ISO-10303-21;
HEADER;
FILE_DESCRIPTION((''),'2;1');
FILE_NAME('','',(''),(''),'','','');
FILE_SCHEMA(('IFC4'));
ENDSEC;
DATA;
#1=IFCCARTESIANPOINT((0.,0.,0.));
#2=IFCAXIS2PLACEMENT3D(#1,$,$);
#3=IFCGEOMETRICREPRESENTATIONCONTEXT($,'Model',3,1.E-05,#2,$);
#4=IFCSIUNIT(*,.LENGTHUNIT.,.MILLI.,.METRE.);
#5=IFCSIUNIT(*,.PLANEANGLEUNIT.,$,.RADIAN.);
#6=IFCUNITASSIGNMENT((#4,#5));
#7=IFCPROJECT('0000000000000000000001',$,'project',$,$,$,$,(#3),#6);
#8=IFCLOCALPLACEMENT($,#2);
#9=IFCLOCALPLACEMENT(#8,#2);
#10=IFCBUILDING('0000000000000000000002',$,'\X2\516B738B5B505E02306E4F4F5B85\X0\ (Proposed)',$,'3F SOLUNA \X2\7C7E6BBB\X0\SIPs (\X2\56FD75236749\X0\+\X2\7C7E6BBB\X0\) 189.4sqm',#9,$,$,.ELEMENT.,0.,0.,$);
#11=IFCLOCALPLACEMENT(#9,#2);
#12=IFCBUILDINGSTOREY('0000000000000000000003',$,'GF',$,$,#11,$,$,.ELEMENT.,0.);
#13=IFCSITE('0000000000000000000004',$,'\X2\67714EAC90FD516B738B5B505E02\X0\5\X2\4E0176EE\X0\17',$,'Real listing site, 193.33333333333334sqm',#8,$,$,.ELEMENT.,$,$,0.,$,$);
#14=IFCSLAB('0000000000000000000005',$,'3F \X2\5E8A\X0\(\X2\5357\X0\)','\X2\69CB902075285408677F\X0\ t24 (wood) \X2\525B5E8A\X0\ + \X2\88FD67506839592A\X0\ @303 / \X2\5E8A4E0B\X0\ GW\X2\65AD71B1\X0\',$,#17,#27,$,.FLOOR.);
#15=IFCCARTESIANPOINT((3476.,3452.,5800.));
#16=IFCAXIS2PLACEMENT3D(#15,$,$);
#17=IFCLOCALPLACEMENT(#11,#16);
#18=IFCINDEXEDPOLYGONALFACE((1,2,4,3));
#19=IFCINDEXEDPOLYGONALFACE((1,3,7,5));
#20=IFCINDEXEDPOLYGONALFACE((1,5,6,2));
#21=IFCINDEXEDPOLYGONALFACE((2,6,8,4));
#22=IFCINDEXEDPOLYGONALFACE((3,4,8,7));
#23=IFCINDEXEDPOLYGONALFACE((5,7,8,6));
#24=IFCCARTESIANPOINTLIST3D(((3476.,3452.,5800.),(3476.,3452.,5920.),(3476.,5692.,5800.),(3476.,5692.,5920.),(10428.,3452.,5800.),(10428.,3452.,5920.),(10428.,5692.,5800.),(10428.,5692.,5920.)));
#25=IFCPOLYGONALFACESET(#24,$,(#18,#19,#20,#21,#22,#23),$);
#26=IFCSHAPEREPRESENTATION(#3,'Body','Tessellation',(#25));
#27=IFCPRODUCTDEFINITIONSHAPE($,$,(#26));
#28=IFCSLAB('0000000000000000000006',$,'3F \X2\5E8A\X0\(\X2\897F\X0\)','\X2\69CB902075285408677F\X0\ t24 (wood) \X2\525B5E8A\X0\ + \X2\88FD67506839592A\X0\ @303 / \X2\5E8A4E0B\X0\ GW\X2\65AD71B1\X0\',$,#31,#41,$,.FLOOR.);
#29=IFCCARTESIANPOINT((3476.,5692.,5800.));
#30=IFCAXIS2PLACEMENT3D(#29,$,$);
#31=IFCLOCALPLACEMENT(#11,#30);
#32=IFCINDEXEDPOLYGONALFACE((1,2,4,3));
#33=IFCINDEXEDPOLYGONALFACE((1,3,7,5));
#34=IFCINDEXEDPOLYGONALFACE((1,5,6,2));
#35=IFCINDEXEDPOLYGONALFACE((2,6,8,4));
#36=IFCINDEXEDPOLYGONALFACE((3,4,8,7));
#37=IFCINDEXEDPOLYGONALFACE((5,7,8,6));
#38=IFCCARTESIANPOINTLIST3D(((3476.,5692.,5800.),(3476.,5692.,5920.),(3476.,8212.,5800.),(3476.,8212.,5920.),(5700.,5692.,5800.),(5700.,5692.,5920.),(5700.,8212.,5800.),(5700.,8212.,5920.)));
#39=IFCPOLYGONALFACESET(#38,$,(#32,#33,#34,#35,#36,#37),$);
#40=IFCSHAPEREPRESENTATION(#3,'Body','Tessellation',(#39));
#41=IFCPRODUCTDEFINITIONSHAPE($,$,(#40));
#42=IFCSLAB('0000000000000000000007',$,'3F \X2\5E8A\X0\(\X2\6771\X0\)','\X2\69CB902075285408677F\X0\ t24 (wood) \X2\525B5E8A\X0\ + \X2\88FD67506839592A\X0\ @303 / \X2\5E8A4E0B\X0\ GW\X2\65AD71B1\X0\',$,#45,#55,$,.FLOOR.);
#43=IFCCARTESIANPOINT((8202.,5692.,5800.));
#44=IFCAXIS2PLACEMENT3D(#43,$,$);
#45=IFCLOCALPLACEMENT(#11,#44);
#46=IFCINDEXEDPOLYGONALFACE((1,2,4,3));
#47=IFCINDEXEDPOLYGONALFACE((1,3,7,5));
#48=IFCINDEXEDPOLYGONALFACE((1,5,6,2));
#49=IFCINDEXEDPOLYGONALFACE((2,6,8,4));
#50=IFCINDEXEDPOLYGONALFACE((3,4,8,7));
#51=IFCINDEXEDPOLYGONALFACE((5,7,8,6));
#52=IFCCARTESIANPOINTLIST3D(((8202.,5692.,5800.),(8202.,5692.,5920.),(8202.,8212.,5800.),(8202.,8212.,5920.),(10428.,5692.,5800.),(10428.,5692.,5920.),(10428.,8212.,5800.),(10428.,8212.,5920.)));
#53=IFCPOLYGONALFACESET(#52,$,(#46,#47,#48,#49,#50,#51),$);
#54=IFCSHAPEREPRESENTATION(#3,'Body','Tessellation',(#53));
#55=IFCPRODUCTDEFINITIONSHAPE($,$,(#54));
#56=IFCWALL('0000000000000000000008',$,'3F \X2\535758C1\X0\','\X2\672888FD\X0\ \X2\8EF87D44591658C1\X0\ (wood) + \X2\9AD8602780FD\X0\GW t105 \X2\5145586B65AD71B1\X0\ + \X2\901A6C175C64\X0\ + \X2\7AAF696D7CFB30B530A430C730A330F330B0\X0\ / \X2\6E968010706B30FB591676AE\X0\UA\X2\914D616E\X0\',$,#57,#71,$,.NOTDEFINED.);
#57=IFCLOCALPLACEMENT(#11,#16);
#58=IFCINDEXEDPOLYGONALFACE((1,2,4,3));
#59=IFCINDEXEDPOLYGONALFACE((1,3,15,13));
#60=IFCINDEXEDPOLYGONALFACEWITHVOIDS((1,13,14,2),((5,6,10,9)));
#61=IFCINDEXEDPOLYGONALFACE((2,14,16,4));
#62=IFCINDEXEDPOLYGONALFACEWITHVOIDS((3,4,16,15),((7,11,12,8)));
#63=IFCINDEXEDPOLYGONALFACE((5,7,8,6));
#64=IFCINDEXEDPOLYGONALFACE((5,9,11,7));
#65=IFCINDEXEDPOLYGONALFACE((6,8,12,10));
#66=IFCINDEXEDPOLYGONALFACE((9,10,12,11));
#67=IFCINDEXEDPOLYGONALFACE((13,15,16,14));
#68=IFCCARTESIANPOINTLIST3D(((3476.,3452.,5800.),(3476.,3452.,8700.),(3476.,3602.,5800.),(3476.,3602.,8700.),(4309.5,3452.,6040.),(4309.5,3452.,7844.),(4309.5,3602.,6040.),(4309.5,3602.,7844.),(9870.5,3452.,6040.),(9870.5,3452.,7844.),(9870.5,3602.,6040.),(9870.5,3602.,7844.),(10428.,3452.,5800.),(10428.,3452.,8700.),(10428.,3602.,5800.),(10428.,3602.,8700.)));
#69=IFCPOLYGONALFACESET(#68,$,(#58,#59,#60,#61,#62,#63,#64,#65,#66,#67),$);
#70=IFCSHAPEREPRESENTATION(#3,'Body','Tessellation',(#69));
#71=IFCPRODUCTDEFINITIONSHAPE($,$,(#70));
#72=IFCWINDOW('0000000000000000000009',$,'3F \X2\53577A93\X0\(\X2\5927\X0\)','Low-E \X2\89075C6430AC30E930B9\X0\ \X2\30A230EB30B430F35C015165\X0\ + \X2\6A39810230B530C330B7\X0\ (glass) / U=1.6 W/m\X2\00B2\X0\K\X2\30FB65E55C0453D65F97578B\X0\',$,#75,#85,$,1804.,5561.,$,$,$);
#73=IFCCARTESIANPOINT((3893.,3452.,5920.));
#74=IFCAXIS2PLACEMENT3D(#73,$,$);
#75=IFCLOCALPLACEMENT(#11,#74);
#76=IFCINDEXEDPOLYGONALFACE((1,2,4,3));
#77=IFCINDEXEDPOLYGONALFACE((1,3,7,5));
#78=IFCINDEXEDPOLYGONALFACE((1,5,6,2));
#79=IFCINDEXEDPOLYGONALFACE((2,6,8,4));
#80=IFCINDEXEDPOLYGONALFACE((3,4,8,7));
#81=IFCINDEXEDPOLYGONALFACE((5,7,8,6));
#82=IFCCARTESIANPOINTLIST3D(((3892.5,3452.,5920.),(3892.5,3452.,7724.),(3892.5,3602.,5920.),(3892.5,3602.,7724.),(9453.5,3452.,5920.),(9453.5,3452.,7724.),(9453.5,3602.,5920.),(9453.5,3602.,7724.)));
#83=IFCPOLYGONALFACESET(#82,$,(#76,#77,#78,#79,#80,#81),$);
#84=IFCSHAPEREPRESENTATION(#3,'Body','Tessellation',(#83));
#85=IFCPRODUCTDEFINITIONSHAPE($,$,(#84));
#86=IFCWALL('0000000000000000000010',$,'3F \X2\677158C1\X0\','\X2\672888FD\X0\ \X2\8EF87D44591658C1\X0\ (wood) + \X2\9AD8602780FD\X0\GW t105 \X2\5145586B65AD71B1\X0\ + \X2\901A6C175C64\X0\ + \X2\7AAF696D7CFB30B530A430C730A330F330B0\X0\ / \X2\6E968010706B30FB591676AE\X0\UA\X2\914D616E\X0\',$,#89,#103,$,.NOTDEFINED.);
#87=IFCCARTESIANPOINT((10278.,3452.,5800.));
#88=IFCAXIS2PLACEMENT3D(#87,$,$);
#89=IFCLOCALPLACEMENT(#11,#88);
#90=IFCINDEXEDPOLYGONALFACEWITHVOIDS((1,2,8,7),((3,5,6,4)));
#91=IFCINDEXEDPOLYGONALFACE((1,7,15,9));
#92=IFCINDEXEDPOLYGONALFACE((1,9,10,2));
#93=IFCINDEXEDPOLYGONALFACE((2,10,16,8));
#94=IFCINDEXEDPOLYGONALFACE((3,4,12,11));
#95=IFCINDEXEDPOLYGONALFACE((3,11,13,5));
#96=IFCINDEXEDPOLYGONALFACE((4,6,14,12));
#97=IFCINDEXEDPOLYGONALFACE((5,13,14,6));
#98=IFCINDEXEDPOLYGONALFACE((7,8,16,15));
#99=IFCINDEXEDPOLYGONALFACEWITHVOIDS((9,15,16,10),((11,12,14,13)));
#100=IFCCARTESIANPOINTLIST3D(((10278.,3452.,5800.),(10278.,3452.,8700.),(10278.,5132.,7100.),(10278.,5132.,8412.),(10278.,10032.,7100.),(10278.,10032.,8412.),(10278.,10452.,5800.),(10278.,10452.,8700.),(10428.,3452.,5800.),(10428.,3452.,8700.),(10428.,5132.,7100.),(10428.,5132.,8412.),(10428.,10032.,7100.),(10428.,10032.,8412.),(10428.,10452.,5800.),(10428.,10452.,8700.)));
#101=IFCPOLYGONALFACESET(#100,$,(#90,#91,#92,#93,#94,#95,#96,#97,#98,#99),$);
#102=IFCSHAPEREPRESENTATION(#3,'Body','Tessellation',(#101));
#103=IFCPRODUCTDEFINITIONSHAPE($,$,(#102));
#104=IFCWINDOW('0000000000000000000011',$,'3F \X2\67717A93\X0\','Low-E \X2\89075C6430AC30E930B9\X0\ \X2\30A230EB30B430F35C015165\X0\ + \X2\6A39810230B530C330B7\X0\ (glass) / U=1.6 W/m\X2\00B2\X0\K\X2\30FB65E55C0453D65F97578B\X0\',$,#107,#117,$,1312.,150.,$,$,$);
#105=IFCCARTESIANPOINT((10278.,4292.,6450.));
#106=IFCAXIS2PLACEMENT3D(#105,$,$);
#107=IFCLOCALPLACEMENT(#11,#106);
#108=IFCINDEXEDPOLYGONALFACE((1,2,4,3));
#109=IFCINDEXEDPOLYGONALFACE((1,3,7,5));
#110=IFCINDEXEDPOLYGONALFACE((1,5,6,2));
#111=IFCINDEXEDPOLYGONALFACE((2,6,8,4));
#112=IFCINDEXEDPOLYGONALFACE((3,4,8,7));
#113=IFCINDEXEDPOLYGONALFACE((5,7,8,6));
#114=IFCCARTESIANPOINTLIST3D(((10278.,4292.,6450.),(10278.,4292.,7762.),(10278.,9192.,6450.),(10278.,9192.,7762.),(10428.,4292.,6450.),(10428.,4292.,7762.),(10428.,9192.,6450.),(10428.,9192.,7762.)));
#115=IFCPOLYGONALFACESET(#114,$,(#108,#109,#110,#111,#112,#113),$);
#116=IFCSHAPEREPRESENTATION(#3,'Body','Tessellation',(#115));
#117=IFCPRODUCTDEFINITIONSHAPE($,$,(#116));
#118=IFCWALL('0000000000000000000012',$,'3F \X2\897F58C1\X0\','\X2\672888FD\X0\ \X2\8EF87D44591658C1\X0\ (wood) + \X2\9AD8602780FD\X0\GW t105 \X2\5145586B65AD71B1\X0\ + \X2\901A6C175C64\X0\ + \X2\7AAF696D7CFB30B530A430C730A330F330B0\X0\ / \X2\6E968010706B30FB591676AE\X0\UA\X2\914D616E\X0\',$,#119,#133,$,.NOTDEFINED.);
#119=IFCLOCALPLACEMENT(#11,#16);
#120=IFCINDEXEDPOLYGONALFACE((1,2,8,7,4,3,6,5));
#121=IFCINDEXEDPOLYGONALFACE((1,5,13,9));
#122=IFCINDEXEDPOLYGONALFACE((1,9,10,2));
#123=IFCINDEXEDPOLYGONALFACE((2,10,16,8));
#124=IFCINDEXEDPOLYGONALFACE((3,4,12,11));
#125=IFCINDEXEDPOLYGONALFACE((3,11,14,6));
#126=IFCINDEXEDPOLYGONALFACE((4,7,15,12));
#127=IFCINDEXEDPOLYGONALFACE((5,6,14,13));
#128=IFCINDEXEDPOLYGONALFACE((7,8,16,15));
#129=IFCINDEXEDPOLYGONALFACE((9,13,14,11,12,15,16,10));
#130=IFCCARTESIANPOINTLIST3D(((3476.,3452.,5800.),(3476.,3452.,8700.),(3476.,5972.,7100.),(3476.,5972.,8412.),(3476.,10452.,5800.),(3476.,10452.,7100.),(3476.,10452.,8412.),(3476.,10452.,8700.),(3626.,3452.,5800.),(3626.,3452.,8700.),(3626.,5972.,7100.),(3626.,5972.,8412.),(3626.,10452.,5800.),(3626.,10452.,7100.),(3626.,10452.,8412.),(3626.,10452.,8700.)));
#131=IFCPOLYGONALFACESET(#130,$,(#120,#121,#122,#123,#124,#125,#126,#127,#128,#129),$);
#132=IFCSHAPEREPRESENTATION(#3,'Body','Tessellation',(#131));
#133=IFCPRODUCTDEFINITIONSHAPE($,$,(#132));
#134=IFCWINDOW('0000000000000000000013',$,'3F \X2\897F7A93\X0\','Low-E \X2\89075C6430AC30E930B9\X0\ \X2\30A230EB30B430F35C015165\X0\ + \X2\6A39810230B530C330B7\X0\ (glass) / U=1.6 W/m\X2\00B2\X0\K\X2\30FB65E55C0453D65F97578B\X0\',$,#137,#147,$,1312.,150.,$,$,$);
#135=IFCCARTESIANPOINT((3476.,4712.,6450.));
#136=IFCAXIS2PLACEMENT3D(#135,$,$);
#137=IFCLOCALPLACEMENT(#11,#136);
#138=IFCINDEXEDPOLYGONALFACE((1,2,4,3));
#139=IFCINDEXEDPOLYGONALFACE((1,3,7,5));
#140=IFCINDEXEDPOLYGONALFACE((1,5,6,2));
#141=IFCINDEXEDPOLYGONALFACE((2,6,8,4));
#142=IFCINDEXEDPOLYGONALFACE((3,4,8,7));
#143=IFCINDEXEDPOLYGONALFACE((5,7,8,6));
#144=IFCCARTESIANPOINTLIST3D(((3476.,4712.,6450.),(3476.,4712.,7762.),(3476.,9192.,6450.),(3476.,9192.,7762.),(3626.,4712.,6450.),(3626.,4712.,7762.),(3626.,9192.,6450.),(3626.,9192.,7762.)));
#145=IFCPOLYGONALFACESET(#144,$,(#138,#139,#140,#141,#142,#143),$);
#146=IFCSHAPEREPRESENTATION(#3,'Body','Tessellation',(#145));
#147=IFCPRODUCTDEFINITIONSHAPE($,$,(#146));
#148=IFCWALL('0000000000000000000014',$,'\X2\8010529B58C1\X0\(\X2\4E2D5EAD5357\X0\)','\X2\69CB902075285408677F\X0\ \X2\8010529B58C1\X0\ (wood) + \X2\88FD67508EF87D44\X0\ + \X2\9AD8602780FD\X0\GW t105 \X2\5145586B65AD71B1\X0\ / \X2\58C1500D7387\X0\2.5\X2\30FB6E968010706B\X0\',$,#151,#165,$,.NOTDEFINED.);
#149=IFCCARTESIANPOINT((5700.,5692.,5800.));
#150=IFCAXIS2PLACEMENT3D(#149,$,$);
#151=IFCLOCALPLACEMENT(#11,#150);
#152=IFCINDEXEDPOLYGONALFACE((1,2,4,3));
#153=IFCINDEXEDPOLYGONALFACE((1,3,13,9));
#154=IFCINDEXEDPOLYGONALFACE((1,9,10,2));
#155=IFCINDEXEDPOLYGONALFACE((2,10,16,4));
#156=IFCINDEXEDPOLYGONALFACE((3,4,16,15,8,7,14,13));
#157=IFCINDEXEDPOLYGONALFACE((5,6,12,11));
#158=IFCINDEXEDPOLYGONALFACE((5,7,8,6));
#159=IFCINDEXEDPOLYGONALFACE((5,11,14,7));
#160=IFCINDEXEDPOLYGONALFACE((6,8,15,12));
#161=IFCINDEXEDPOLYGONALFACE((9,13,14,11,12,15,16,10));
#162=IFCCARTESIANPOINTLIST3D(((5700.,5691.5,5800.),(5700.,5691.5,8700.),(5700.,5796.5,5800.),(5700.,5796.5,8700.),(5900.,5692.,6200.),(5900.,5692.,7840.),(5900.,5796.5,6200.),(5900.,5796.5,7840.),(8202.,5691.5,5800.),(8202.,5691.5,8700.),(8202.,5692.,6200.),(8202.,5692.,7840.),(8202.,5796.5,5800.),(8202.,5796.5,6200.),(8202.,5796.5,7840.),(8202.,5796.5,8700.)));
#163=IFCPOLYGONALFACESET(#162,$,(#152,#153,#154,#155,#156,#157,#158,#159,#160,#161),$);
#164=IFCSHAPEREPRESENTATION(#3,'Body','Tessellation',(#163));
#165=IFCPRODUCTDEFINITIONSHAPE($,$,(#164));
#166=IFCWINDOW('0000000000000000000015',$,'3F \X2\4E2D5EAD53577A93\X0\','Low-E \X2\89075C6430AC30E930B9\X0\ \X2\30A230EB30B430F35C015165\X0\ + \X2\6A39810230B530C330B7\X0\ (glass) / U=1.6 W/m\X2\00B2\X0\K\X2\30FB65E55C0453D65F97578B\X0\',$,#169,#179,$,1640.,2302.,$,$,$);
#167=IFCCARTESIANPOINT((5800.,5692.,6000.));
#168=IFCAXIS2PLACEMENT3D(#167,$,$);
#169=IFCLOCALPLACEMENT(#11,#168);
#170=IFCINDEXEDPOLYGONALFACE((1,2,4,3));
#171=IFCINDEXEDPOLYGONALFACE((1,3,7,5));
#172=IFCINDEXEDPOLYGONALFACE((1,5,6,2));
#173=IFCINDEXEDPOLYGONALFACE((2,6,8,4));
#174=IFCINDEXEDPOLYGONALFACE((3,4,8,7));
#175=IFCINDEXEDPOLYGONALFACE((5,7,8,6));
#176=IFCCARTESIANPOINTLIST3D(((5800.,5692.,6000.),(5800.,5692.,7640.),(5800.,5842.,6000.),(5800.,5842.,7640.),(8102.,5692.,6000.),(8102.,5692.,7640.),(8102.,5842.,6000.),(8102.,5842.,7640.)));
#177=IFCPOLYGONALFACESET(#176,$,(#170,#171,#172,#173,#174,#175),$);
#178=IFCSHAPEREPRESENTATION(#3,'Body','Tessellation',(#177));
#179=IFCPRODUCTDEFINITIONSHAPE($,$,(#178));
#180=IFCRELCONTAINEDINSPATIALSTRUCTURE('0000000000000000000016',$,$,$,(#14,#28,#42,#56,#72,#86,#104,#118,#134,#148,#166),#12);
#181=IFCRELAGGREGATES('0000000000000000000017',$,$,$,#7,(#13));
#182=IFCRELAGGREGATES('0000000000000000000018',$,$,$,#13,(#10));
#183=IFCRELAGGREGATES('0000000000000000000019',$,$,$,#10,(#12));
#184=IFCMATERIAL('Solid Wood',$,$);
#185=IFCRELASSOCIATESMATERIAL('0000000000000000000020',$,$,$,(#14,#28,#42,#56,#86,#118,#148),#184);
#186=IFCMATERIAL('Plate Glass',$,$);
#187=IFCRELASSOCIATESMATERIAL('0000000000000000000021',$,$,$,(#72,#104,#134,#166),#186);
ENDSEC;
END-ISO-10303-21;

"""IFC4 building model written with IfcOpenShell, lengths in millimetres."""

from ifc_helpers import new_model, si_unit, frame, frame_2d, origin, place, context, project, spatial, rectangle, extrude, material, element, fill, save


model = new_model("IFC4")

# Units and contexts
model_context = context("Model", 3, precision=1e-05, world=origin())
ifc_project = project(units=[si_unit("LENGTHUNIT", "METRE", prefix="MILLI"), si_unit("PLANEANGLEUNIT", "RADIAN")], contexts=[model_context])

# Site, building, storey
site_placement = place(None, origin())
site = spatial("IfcSite", under=ifc_project, at=site_placement, Name="東京都八王子市5丁目17", ObjectType="Real listing site, 193.33333333333334sqm", CompositionType="ELEMENT", RefElevation=0.0)
building_placement = place(site_placement, origin())
building = spatial("IfcBuilding", under=site, at=building_placement, Name="八王子市の住宅 (Proposed)", ObjectType="3F SOLUNA 籾殻SIPs (国産杉+籾殻) 189.4sqm", CompositionType="ELEMENT", ElevationOfRefHeight=0.0, ElevationOfTerrain=0.0)
storey_placement = place(building_placement, origin())
storey = spatial("IfcBuildingStorey", under=building, at=storey_placement, Name="GF", CompositionType="ELEMENT", Elevation=0.0)

# Slabs
ifc_material_1 = material(Name="Solid Wood")
slab_1_placement = place(storey_placement, frame((3476.0, 3452.0, 5800.0)))
element("IfcSlab", 1, at=slab_1_placement, inside=storey, material=ifc_material_1, Name="3F 床(南)", Description="構造用合板 t24 (wood) 剛床 + 製材根太 @303 / 床下 GW断熱", PredefinedType="FLOOR", context=model_context, shape_type="SweptSolid", body=[
    extrude(rectangle(XDim=6952.0, YDim=2240.0, at=frame_2d((3476.0, 1120.0))), frame((3476.0, 3452.0, 5800.0)), (0.0, 0.0, 1.0), 120.0),
])
slab_2_placement = place(storey_placement, frame((3476.0, 5692.0, 5800.0)))
element("IfcSlab", 2, at=slab_2_placement, inside=storey, material=ifc_material_1, Name="3F 床(西)", Description="構造用合板 t24 (wood) 剛床 + 製材根太 @303 / 床下 GW断熱", PredefinedType="FLOOR", context=model_context, shape_type="SweptSolid", body=[
    extrude(rectangle(XDim=2224.0, YDim=2520.0, at=frame_2d((1112.0, 1260.0))), frame((3476.0, 5692.0, 5800.0)), (0.0, 0.0, 1.0), 120.0),
])
slab_3_placement = place(storey_placement, frame((8202.0, 5692.0, 5800.0)))
element("IfcSlab", 3, at=slab_3_placement, inside=storey, material=ifc_material_1, Name="3F 床(東)", Description="構造用合板 t24 (wood) 剛床 + 製材根太 @303 / 床下 GW断熱", PredefinedType="FLOOR", context=model_context, shape_type="SweptSolid", body=[
    extrude(rectangle(XDim=2226.0, YDim=2520.0, at=frame_2d((1113.0, 1260.0))), frame((8202.0, 5692.0, 5800.0)), (0.0, 0.0, 1.0), 120.0),
])

# Walls, openings, windows
wall_1_placement = place(storey_placement, frame((3476.0, 3452.0, 5800.0)))
wall_1 = element("IfcWall", 4, at=wall_1_placement, inside=storey, material=ifc_material_1, Name="3F 南壁", Description="木製 軸組外壁 (wood) + 高性能GW t105 充填断熱 + 通気層 + 窯業系サイディング / 準耐火・外皮UA配慮", PredefinedType="NOTDEFINED", context=model_context, shape_type="SweptSolid", body=[
    extrude(rectangle(XDim=6952.0, YDim=150.0, at=frame_2d((3476.0, 75.0))), frame((3476.0, 3452.0, 5800.0)), (0.0, 0.0, 1.0), 2900.0),
])
opening_1_placement = place(storey_placement, frame((3893.0, 3452.0, 5920.0)))
opening_1 = element("IfcOpeningElement", 5, at=opening_1_placement, cuts=wall_1, PredefinedType="NOTDEFINED", context=model_context, shape_type="SweptSolid", body=[
    extrude(rectangle(XDim=5561.0, YDim=150.0, at=frame_2d((2780.0, 75.0))), frame((3893.0, 3452.0, 5920.0)), (0.0, 0.0, 1.0), 1804.0),
])
ifc_material_2 = material(Name="Plate Glass")
window_1_placement = place(storey_placement, frame((3893.0, 3452.0, 5920.0)))
window_1 = element("IfcWindow", 6, at=window_1_placement, inside=storey, material=ifc_material_2, Name="3F 南窓(大)", Description="Low-E 複層ガラス アルゴン封入 + 樹脂サッシ (glass) / U=1.6 W/m²K・日射取得型", OverallHeight=1804.0, OverallWidth=5561.0, context=model_context, shape_type="SweptSolid", body=[
    extrude(rectangle(XDim=5561.0, YDim=150.0, at=frame_2d((2780.0, 75.0))), frame((3893.0, 3452.0, 5920.0)), (0.0, 0.0, 1.0), 1804.0),
])
fill(opening_1, window_1)
wall_2_placement = place(storey_placement, frame((10278.0, 3452.0, 5800.0)))
wall_2 = element("IfcWall", 7, at=wall_2_placement, inside=storey, material=ifc_material_1, Name="3F 東壁", Description="木製 軸組外壁 (wood) + 高性能GW t105 充填断熱 + 通気層 + 窯業系サイディング / 準耐火・外皮UA配慮", PredefinedType="NOTDEFINED", context=model_context, shape_type="SweptSolid", body=[
    extrude(rectangle(XDim=150.0, YDim=7000.0, at=frame_2d((75.0, 3500.0))), frame((10278.0, 3452.0, 5800.0)), (0.0, 0.0, 1.0), 2900.0),
])
opening_2_placement = place(storey_placement, frame((10278.0, 4292.0, 6450.0)))
opening_2 = element("IfcOpeningElement", 8, at=opening_2_placement, cuts=wall_2, PredefinedType="NOTDEFINED", context=model_context, shape_type="SweptSolid", body=[
    extrude(rectangle(XDim=150.0, YDim=4900.0, at=frame_2d((75.0, 2450.0))), frame((10278.0, 4292.0, 6450.0)), (0.0, 0.0, 1.0), 1312.0),
])
window_2_placement = place(storey_placement, frame((10278.0, 4292.0, 6450.0)))
window_2 = element("IfcWindow", 9, at=window_2_placement, inside=storey, material=ifc_material_2, Name="3F 東窓", Description="Low-E 複層ガラス アルゴン封入 + 樹脂サッシ (glass) / U=1.6 W/m²K・日射取得型", OverallHeight=1312.0, OverallWidth=150.0, context=model_context, shape_type="SweptSolid", body=[
    extrude(rectangle(XDim=150.0, YDim=4900.0, at=frame_2d((75.0, 2450.0))), frame((10278.0, 4292.0, 6450.0)), (0.0, 0.0, 1.0), 1312.0),
])
fill(opening_2, window_2)
wall_3_placement = place(storey_placement, frame((3476.0, 3452.0, 5800.0)))
wall_3 = element("IfcWall", 10, at=wall_3_placement, inside=storey, material=ifc_material_1, Name="3F 西壁", Description="木製 軸組外壁 (wood) + 高性能GW t105 充填断熱 + 通気層 + 窯業系サイディング / 準耐火・外皮UA配慮", PredefinedType="NOTDEFINED", context=model_context, shape_type="SweptSolid", body=[
    extrude(rectangle(XDim=150.0, YDim=7000.0, at=frame_2d((75.0, 3500.0))), frame((3476.0, 3452.0, 5800.0)), (0.0, 0.0, 1.0), 2900.0),
])
opening_3_placement = place(storey_placement, frame((3476.0, 4712.0, 6450.0)))
opening_3 = element("IfcOpeningElement", 11, at=opening_3_placement, cuts=wall_3, PredefinedType="NOTDEFINED", context=model_context, shape_type="SweptSolid", body=[
    extrude(rectangle(XDim=150.0, YDim=4480.0, at=frame_2d((75.0, 2240.0))), frame((3476.0, 4712.0, 6450.0)), (0.0, 0.0, 1.0), 1312.0),
])
window_3_placement = place(storey_placement, frame((3476.0, 4712.0, 6450.0)))
window_3 = element("IfcWindow", 12, at=window_3_placement, inside=storey, material=ifc_material_2, Name="3F 西窓", Description="Low-E 複層ガラス アルゴン封入 + 樹脂サッシ (glass) / U=1.6 W/m²K・日射取得型", OverallHeight=1312.0, OverallWidth=150.0, context=model_context, shape_type="SweptSolid", body=[
    extrude(rectangle(XDim=150.0, YDim=4480.0, at=frame_2d((75.0, 2240.0))), frame((3476.0, 4712.0, 6450.0)), (0.0, 0.0, 1.0), 1312.0),
])
fill(opening_3, window_3)
wall_4_placement = place(storey_placement, frame((5700.0, 5692.0, 5800.0)))
wall_4 = element("IfcWall", 13, at=wall_4_placement, inside=storey, material=ifc_material_1, Name="耐力壁(中庭南)", Description="構造用合板 耐力壁 (wood) + 製材軸組 + 高性能GW t105 充填断熱 / 壁倍率2.5・準耐火", PredefinedType="NOTDEFINED", context=model_context, shape_type="SweptSolid", body=[
    extrude(rectangle(XDim=2502.0, YDim=105.0, at=frame_2d((1251.0, 52.0))), frame((5700.0, 5692.0, 5800.0)), (0.0, 0.0, 1.0), 2900.0),
])
opening_4_placement = place(storey_placement, frame((5800.0, 5692.0, 6000.0)))
opening_4 = element("IfcOpeningElement", 14, at=opening_4_placement, cuts=wall_4, PredefinedType="NOTDEFINED", context=model_context, shape_type="SweptSolid", body=[
    extrude(rectangle(XDim=2302.0, YDim=150.0, at=frame_2d((1151.0, 75.0))), frame((5800.0, 5692.0, 6000.0)), (0.0, 0.0, 1.0), 1640.0),
])
window_4_placement = place(storey_placement, frame((5800.0, 5692.0, 6000.0)))
window_4 = element("IfcWindow", 15, at=window_4_placement, inside=storey, material=ifc_material_2, Name="3F 中庭南窓", Description="Low-E 複層ガラス アルゴン封入 + 樹脂サッシ (glass) / U=1.6 W/m²K・日射取得型", OverallHeight=1640.0, OverallWidth=2302.0, context=model_context, shape_type="SweptSolid", body=[
    extrude(rectangle(XDim=2302.0, YDim=150.0, at=frame_2d((1151.0, 75.0))), frame((5800.0, 5692.0, 6000.0)), (0.0, 0.0, 1.0), 1640.0),
])
fill(opening_4, window_4)

save(model, "model.ifc")
